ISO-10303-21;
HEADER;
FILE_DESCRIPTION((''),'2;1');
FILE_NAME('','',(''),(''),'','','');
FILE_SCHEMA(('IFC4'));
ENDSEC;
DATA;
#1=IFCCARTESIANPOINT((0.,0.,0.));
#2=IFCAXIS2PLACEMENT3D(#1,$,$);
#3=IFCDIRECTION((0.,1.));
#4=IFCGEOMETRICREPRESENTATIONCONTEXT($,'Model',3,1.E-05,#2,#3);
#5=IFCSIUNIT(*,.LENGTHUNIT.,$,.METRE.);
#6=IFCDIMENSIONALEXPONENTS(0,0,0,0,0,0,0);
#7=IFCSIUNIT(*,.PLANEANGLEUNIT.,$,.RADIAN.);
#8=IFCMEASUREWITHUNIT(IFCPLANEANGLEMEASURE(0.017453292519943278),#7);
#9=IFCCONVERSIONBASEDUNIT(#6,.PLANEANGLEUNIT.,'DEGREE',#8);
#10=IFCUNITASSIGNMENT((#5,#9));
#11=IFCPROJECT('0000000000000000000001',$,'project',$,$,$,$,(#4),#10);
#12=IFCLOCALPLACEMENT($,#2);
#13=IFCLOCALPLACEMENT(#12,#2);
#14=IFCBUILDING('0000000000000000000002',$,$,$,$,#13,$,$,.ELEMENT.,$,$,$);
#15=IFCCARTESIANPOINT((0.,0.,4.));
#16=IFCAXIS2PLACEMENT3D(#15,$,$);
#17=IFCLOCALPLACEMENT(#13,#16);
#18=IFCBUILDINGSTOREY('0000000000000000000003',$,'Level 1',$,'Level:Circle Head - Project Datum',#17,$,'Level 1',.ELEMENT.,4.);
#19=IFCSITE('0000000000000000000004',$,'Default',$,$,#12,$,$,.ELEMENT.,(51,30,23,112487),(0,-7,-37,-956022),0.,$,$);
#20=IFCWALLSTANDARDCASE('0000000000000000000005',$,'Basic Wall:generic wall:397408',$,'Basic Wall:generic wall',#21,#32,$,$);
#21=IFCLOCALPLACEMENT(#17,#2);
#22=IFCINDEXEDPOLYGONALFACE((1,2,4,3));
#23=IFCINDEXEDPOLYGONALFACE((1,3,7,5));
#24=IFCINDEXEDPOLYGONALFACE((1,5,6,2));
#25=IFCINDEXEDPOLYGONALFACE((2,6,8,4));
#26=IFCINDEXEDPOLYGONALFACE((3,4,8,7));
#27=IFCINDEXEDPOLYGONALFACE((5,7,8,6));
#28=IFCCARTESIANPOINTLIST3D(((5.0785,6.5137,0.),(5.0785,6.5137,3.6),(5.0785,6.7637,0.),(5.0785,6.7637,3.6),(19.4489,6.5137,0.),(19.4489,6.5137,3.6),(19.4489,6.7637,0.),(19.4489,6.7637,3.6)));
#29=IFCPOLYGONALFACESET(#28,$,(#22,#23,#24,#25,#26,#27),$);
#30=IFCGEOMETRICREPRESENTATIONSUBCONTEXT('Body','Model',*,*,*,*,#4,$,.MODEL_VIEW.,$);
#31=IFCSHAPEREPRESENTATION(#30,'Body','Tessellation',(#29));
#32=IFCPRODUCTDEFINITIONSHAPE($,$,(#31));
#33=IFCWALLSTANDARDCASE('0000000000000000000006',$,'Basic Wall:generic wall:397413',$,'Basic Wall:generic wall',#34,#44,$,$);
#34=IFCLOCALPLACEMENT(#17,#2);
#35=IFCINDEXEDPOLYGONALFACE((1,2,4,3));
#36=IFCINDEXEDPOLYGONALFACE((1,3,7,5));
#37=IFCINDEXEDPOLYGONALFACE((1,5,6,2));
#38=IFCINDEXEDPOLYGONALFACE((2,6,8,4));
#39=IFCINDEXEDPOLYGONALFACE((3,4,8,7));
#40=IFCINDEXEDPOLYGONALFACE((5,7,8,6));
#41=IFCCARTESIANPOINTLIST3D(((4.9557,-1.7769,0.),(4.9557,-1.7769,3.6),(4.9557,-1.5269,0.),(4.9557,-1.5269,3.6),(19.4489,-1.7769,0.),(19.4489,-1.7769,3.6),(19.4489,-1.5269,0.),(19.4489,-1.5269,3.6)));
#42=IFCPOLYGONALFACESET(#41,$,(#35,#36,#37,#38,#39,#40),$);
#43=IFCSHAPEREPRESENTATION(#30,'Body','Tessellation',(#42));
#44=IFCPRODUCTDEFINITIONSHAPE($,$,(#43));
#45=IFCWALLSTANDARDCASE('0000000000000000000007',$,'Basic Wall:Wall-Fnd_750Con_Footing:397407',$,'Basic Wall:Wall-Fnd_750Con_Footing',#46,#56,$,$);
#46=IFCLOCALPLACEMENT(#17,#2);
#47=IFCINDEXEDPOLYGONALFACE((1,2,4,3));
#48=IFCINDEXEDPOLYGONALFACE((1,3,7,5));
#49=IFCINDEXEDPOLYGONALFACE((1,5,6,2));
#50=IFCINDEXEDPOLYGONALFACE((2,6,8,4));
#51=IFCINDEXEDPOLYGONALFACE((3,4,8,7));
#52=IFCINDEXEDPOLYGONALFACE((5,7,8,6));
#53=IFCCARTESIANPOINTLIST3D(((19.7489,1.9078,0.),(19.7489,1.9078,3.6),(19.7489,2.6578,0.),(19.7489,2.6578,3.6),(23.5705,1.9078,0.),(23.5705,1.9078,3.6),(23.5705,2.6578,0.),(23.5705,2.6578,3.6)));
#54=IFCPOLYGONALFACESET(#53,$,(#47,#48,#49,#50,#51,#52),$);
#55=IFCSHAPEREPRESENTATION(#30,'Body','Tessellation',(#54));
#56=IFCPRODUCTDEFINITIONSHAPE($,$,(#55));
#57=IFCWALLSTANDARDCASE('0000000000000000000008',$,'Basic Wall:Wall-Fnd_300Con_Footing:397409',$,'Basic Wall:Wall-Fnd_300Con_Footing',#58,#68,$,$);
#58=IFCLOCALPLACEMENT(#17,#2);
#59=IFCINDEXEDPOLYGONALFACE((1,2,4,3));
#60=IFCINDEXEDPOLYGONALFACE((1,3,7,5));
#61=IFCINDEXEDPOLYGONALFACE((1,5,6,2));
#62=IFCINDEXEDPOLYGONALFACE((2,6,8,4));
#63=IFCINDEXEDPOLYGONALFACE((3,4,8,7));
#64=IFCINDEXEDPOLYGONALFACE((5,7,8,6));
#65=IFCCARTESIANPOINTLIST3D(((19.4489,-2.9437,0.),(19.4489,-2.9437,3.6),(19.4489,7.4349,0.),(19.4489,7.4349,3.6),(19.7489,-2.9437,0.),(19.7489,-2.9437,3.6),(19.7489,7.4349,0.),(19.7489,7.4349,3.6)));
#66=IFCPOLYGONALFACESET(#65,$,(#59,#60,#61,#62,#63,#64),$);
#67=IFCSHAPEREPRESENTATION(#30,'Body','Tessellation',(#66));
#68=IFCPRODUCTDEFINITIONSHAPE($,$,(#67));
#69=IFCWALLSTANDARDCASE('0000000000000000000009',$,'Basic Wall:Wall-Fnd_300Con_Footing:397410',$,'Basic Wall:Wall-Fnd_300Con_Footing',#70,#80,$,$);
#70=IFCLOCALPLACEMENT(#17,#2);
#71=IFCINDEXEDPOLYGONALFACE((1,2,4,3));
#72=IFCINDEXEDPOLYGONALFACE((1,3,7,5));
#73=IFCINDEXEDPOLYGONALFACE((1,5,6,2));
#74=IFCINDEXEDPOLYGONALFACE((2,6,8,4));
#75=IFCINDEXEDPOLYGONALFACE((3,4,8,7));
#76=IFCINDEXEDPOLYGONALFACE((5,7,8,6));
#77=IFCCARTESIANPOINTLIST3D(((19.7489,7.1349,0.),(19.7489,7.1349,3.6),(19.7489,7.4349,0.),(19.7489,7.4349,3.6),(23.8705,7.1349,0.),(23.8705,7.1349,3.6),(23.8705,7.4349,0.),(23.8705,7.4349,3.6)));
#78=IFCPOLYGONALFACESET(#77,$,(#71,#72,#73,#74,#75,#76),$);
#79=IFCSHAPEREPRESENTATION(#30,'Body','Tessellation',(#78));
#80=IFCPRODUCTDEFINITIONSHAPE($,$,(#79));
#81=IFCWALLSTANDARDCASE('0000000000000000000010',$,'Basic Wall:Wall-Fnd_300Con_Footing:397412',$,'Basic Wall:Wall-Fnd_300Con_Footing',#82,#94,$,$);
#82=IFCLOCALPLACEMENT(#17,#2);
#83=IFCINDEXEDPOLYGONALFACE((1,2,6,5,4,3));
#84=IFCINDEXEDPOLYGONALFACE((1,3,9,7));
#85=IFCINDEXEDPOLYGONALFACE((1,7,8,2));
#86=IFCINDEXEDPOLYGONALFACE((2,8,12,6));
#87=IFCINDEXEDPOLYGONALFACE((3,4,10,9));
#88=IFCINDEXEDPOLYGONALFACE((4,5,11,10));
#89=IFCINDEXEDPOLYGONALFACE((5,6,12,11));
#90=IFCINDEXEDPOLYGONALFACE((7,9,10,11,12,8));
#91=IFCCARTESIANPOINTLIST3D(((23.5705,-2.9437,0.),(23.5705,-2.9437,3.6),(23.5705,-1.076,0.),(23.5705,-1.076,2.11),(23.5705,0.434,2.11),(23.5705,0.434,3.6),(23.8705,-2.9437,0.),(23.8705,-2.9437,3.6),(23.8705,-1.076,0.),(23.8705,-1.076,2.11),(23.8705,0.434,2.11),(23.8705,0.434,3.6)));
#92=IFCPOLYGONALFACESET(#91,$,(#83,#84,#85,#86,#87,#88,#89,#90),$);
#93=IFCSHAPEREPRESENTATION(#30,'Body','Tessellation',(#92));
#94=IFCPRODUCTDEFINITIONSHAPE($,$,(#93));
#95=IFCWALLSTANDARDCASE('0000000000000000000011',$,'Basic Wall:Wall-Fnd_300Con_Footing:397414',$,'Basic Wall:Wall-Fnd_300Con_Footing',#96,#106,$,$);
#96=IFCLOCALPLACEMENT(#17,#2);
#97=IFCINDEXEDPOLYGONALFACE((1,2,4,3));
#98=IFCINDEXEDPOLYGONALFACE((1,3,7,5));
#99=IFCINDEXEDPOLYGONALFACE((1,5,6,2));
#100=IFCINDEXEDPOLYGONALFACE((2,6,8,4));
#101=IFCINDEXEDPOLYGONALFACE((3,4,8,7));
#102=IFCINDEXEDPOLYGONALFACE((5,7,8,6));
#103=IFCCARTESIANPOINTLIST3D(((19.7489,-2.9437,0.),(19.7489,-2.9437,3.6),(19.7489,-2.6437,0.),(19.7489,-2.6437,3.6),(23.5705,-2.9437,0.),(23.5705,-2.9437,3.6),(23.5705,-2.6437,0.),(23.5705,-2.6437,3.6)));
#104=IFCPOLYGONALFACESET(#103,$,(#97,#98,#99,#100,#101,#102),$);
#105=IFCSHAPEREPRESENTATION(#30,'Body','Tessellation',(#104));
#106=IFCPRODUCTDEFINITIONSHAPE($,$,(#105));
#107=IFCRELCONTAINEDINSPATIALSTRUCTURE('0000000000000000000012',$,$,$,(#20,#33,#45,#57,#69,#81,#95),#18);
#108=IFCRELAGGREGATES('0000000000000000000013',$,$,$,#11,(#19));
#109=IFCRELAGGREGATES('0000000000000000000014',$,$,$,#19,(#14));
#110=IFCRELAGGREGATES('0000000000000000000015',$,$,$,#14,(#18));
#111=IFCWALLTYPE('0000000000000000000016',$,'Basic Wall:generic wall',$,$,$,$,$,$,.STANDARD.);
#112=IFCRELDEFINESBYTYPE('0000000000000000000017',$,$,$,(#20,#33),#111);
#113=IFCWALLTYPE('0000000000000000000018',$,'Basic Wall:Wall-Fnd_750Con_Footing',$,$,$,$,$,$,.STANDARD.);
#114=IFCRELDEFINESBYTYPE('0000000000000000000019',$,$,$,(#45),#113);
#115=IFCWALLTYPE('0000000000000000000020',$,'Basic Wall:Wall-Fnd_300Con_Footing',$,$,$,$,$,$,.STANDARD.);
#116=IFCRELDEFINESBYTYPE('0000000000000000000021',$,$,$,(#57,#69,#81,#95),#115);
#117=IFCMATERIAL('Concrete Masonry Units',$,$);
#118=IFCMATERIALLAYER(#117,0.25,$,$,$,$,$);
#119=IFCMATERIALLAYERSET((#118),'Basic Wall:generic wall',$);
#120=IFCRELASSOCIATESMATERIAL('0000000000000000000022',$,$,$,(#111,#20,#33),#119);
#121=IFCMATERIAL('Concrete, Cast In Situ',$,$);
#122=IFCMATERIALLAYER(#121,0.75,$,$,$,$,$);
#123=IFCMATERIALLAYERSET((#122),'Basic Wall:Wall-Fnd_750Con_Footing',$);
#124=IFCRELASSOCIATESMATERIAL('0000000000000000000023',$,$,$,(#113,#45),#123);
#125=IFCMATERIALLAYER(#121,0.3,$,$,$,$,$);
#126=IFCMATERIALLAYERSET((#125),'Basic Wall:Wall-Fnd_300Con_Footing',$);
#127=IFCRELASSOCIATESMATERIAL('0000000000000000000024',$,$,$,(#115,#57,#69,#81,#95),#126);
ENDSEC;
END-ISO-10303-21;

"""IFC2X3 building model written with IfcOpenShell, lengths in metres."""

from ifc_helpers import new_model, entity, si_unit, converted_unit, direction, frame, frame_2d, origin, place, context, subcontext, project, spatial, rectangle, extrude, material, layer, layer_set, layer_usage, type_object, element, save


model = new_model("IFC2X3")

# Units and contexts
model_context = context("Model", 3, precision=1e-05, world=origin(), true_north=direction((0.0, 1.0)))
body_context = subcontext(model_context, "Body", "Model", "MODEL_VIEW")
ifc_project = project(units=[si_unit("LENGTHUNIT", "METRE"), converted_unit("PLANEANGLEUNIT", "DEGREE", entity("IfcPlaneAngleMeasure", 0.017453292519943278), si_unit("PLANEANGLEUNIT", "RADIAN"), dimensions=[0, 0, 0, 0, 0, 0, 0])], contexts=[model_context])

# Site, building, storey
site_placement = place(None, origin())
site = spatial("IfcSite", under=ifc_project, at=site_placement, Name="Default", CompositionType="ELEMENT", RefLatitude=(51, 30, 23, 112487), RefLongitude=(0, -7, -37, -956022), RefElevation=0.0)
building_placement = place(site_placement, origin())
building = spatial("IfcBuilding", under=site, at=building_placement, CompositionType="ELEMENT")
storey_placement = place(building_placement, frame((0.0, 0.0, 4.0)))
storey = spatial("IfcBuildingStorey", under=building, at=storey_placement, Name="Level 1", ObjectType="Level:Circle Head - Project Datum", LongName="Level 1", CompositionType="ELEMENT", Elevation=4.0)

# Shared definitions
ifc_material_1 = material(Name="Concrete Masonry Units")
ifc_layer_1 = layer(ifc_material_1, 0.25)
ifc_layer_set_1 = layer_set([ifc_layer_1], Name="Basic Wall:generic wall")
wall_type_1 = type_object("IfcWallType", Name="Basic Wall:generic wall", PredefinedType="STANDARD", material=ifc_layer_set_1)

# Walls
ifc_layer_usage_1 = layer_usage(ifc_layer_set_1, "AXIS2", "NEGATIVE", 0.125)
wall_1_placement = place(storey_placement, frame((19.4489, 6.6387, 0.0), z_axis=(0.0, 0.0, 1.0), x_axis=(-1.0, 0.0, 0.0)))
element("IfcWallStandardCase", 1, at=wall_1_placement, inside=storey, type_object=wall_type_1, material=ifc_layer_usage_1, Name="Basic Wall:generic wall:397408", ObjectType="Basic Wall:generic wall", context=body_context, shape_type="SweptSolid", body=[
    extrude(rectangle(XDim=14.3703, YDim=0.25, at=frame_2d((7.1852, 0.0), x_axis=(-1.0, 0.0))), origin(), (0.0, 0.0, 1.0), 3.6),
])
ifc_layer_usage_2 = layer_usage(ifc_layer_set_1, "AXIS2", "NEGATIVE", 0.125)
wall_2_placement = place(storey_placement, frame((19.4489, -1.6519, 0.0), z_axis=(0.0, 0.0, 1.0), x_axis=(-1.0, 0.0, 0.0)))
element("IfcWallStandardCase", 2, at=wall_2_placement, inside=storey, type_object=wall_type_1, material=ifc_layer_usage_2, Name="Basic Wall:generic wall:397413", ObjectType="Basic Wall:generic wall", context=body_context, shape_type="SweptSolid", body=[
    extrude(rectangle(XDim=14.4932, YDim=0.25, at=frame_2d((7.2466, 0.0), x_axis=(-1.0, 0.0))), origin(), (0.0, 0.0, 1.0), 3.6),
])
ifc_material_2 = material(Name="Concrete, Cast In Situ")
ifc_layer_2 = layer(ifc_material_2, 0.75)
ifc_layer_set_2 = layer_set([ifc_layer_2], Name="Basic Wall:Wall-Fnd_750Con_Footing")
ifc_layer_usage_3 = layer_usage(ifc_layer_set_2, "AXIS2", "NEGATIVE", 0.375)
wall_type_2 = type_object("IfcWallType", Name="Basic Wall:Wall-Fnd_750Con_Footing", PredefinedType="STANDARD", material=ifc_layer_set_2)
wall_3_placement = place(storey_placement, frame((23.5705, 2.2828, 0.0), z_axis=(0.0, 0.0, 1.0), x_axis=(-1.0, 0.0, 0.0)))
element("IfcWallStandardCase", 3, at=wall_3_placement, inside=storey, type_object=wall_type_2, material=ifc_layer_usage_3, Name="Basic Wall:Wall-Fnd_750Con_Footing:397407", ObjectType="Basic Wall:Wall-Fnd_750Con_Footing", context=body_context, shape_type="SweptSolid", body=[
    extrude(rectangle(XDim=3.8216, YDim=0.75, at=frame_2d((1.9108, 0.0), x_axis=(-1.0, 0.0))), origin(), (0.0, 0.0, 1.0), 3.6),
])
ifc_layer_3 = layer(ifc_material_2, 0.3)
ifc_layer_set_3 = layer_set([ifc_layer_3], Name="Basic Wall:Wall-Fnd_300Con_Footing")
ifc_layer_usage_4 = layer_usage(ifc_layer_set_3, "AXIS2", "NEGATIVE", 0.15)
wall_type_3 = type_object("IfcWallType", Name="Basic Wall:Wall-Fnd_300Con_Footing", PredefinedType="STANDARD", material=ifc_layer_set_3)
wall_4_placement = place(storey_placement, frame((19.5989, -2.9437, 0.0), z_axis=(0.0, 0.0, 1.0), x_axis=(0.0, 1.0, 0.0)))
element("IfcWallStandardCase", 4, at=wall_4_placement, inside=storey, type_object=wall_type_3, material=ifc_layer_usage_4, Name="Basic Wall:Wall-Fnd_300Con_Footing:397409", ObjectType="Basic Wall:Wall-Fnd_300Con_Footing", context=body_context, shape_type="SweptSolid", body=[
    extrude(rectangle(XDim=10.3786, YDim=0.3, at=frame_2d((5.1893, 0.0), x_axis=(-1.0, 0.0))), origin(), (0.0, 0.0, 1.0), 3.6),
])
ifc_layer_usage_5 = layer_usage(ifc_layer_set_3, "AXIS2", "NEGATIVE", 0.15)
wall_5_placement = place(storey_placement, frame((19.7489, 7.2849, 0.0)))
element("IfcWallStandardCase", 5, at=wall_5_placement, inside=storey, type_object=wall_type_3, material=ifc_layer_usage_5, Name="Basic Wall:Wall-Fnd_300Con_Footing:397410", ObjectType="Basic Wall:Wall-Fnd_300Con_Footing", context=body_context, shape_type="SweptSolid", body=[
    extrude(rectangle(XDim=4.1216, YDim=0.3, at=frame_2d((2.0608, 0.0), x_axis=(-1.0, 0.0))), origin(), (0.0, 0.0, 1.0), 3.6),
])

# Wall, opening
ifc_layer_usage_6 = layer_usage(ifc_layer_set_3, "AXIS2", "NEGATIVE", 0.15)
wall_6_placement = place(storey_placement, frame((23.7205, 0.434, 0.0), z_axis=(0.0, 0.0, 1.0), x_axis=(0.0, -1.0, 0.0)))
wall_6 = element("IfcWallStandardCase", 6, at=wall_6_placement, inside=storey, type_object=wall_type_3, material=ifc_layer_usage_6, Name="Basic Wall:Wall-Fnd_300Con_Footing:397412", ObjectType="Basic Wall:Wall-Fnd_300Con_Footing", context=body_context, shape_type="SweptSolid", body=[
    extrude(rectangle(XDim=3.3776, YDim=0.3, at=frame_2d((1.6888, 0.0), x_axis=(-1.0, 0.0))), origin(), (0.0, 0.0, 1.0), 3.6),
])
opening_1_placement = place(wall_6_placement, frame((1.51, 0.15, 0.0)))
element("IfcOpeningElement", 7, at=opening_1_placement, cuts=wall_6, ObjectType="Opening", context=body_context, shape_type="SweptSolid", body=[
    extrude(rectangle(XDim=2.11, YDim=1.81, at=frame_2d((1.055, 0.905), x_axis=(-1.0, 0.0))), frame((0.0, 0.0, 0.0), z_axis=(0.0, -1.0, 0.0), x_axis=(0.0, 0.0, 1.0)), (0.0, 0.0, 1.0), 0.3),
])

# Wall
ifc_layer_usage_7 = layer_usage(ifc_layer_set_3, "AXIS2", "NEGATIVE", 0.15)
wall_7_placement = place(storey_placement, frame((23.5705, -2.7937, 0.0), z_axis=(0.0, 0.0, 1.0), x_axis=(-1.0, 0.0, 0.0)))
element("IfcWallStandardCase", 8, at=wall_7_placement, inside=storey, type_object=wall_type_3, material=ifc_layer_usage_7, Name="Basic Wall:Wall-Fnd_300Con_Footing:397414", ObjectType="Basic Wall:Wall-Fnd_300Con_Footing", context=body_context, shape_type="SweptSolid", body=[
    extrude(rectangle(XDim=3.8216, YDim=0.3, at=frame_2d((1.9108, 0.0), x_axis=(-1.0, 0.0))), origin(), (0.0, 0.0, 1.0), 3.6),
])

save(model, "model.ifc")
